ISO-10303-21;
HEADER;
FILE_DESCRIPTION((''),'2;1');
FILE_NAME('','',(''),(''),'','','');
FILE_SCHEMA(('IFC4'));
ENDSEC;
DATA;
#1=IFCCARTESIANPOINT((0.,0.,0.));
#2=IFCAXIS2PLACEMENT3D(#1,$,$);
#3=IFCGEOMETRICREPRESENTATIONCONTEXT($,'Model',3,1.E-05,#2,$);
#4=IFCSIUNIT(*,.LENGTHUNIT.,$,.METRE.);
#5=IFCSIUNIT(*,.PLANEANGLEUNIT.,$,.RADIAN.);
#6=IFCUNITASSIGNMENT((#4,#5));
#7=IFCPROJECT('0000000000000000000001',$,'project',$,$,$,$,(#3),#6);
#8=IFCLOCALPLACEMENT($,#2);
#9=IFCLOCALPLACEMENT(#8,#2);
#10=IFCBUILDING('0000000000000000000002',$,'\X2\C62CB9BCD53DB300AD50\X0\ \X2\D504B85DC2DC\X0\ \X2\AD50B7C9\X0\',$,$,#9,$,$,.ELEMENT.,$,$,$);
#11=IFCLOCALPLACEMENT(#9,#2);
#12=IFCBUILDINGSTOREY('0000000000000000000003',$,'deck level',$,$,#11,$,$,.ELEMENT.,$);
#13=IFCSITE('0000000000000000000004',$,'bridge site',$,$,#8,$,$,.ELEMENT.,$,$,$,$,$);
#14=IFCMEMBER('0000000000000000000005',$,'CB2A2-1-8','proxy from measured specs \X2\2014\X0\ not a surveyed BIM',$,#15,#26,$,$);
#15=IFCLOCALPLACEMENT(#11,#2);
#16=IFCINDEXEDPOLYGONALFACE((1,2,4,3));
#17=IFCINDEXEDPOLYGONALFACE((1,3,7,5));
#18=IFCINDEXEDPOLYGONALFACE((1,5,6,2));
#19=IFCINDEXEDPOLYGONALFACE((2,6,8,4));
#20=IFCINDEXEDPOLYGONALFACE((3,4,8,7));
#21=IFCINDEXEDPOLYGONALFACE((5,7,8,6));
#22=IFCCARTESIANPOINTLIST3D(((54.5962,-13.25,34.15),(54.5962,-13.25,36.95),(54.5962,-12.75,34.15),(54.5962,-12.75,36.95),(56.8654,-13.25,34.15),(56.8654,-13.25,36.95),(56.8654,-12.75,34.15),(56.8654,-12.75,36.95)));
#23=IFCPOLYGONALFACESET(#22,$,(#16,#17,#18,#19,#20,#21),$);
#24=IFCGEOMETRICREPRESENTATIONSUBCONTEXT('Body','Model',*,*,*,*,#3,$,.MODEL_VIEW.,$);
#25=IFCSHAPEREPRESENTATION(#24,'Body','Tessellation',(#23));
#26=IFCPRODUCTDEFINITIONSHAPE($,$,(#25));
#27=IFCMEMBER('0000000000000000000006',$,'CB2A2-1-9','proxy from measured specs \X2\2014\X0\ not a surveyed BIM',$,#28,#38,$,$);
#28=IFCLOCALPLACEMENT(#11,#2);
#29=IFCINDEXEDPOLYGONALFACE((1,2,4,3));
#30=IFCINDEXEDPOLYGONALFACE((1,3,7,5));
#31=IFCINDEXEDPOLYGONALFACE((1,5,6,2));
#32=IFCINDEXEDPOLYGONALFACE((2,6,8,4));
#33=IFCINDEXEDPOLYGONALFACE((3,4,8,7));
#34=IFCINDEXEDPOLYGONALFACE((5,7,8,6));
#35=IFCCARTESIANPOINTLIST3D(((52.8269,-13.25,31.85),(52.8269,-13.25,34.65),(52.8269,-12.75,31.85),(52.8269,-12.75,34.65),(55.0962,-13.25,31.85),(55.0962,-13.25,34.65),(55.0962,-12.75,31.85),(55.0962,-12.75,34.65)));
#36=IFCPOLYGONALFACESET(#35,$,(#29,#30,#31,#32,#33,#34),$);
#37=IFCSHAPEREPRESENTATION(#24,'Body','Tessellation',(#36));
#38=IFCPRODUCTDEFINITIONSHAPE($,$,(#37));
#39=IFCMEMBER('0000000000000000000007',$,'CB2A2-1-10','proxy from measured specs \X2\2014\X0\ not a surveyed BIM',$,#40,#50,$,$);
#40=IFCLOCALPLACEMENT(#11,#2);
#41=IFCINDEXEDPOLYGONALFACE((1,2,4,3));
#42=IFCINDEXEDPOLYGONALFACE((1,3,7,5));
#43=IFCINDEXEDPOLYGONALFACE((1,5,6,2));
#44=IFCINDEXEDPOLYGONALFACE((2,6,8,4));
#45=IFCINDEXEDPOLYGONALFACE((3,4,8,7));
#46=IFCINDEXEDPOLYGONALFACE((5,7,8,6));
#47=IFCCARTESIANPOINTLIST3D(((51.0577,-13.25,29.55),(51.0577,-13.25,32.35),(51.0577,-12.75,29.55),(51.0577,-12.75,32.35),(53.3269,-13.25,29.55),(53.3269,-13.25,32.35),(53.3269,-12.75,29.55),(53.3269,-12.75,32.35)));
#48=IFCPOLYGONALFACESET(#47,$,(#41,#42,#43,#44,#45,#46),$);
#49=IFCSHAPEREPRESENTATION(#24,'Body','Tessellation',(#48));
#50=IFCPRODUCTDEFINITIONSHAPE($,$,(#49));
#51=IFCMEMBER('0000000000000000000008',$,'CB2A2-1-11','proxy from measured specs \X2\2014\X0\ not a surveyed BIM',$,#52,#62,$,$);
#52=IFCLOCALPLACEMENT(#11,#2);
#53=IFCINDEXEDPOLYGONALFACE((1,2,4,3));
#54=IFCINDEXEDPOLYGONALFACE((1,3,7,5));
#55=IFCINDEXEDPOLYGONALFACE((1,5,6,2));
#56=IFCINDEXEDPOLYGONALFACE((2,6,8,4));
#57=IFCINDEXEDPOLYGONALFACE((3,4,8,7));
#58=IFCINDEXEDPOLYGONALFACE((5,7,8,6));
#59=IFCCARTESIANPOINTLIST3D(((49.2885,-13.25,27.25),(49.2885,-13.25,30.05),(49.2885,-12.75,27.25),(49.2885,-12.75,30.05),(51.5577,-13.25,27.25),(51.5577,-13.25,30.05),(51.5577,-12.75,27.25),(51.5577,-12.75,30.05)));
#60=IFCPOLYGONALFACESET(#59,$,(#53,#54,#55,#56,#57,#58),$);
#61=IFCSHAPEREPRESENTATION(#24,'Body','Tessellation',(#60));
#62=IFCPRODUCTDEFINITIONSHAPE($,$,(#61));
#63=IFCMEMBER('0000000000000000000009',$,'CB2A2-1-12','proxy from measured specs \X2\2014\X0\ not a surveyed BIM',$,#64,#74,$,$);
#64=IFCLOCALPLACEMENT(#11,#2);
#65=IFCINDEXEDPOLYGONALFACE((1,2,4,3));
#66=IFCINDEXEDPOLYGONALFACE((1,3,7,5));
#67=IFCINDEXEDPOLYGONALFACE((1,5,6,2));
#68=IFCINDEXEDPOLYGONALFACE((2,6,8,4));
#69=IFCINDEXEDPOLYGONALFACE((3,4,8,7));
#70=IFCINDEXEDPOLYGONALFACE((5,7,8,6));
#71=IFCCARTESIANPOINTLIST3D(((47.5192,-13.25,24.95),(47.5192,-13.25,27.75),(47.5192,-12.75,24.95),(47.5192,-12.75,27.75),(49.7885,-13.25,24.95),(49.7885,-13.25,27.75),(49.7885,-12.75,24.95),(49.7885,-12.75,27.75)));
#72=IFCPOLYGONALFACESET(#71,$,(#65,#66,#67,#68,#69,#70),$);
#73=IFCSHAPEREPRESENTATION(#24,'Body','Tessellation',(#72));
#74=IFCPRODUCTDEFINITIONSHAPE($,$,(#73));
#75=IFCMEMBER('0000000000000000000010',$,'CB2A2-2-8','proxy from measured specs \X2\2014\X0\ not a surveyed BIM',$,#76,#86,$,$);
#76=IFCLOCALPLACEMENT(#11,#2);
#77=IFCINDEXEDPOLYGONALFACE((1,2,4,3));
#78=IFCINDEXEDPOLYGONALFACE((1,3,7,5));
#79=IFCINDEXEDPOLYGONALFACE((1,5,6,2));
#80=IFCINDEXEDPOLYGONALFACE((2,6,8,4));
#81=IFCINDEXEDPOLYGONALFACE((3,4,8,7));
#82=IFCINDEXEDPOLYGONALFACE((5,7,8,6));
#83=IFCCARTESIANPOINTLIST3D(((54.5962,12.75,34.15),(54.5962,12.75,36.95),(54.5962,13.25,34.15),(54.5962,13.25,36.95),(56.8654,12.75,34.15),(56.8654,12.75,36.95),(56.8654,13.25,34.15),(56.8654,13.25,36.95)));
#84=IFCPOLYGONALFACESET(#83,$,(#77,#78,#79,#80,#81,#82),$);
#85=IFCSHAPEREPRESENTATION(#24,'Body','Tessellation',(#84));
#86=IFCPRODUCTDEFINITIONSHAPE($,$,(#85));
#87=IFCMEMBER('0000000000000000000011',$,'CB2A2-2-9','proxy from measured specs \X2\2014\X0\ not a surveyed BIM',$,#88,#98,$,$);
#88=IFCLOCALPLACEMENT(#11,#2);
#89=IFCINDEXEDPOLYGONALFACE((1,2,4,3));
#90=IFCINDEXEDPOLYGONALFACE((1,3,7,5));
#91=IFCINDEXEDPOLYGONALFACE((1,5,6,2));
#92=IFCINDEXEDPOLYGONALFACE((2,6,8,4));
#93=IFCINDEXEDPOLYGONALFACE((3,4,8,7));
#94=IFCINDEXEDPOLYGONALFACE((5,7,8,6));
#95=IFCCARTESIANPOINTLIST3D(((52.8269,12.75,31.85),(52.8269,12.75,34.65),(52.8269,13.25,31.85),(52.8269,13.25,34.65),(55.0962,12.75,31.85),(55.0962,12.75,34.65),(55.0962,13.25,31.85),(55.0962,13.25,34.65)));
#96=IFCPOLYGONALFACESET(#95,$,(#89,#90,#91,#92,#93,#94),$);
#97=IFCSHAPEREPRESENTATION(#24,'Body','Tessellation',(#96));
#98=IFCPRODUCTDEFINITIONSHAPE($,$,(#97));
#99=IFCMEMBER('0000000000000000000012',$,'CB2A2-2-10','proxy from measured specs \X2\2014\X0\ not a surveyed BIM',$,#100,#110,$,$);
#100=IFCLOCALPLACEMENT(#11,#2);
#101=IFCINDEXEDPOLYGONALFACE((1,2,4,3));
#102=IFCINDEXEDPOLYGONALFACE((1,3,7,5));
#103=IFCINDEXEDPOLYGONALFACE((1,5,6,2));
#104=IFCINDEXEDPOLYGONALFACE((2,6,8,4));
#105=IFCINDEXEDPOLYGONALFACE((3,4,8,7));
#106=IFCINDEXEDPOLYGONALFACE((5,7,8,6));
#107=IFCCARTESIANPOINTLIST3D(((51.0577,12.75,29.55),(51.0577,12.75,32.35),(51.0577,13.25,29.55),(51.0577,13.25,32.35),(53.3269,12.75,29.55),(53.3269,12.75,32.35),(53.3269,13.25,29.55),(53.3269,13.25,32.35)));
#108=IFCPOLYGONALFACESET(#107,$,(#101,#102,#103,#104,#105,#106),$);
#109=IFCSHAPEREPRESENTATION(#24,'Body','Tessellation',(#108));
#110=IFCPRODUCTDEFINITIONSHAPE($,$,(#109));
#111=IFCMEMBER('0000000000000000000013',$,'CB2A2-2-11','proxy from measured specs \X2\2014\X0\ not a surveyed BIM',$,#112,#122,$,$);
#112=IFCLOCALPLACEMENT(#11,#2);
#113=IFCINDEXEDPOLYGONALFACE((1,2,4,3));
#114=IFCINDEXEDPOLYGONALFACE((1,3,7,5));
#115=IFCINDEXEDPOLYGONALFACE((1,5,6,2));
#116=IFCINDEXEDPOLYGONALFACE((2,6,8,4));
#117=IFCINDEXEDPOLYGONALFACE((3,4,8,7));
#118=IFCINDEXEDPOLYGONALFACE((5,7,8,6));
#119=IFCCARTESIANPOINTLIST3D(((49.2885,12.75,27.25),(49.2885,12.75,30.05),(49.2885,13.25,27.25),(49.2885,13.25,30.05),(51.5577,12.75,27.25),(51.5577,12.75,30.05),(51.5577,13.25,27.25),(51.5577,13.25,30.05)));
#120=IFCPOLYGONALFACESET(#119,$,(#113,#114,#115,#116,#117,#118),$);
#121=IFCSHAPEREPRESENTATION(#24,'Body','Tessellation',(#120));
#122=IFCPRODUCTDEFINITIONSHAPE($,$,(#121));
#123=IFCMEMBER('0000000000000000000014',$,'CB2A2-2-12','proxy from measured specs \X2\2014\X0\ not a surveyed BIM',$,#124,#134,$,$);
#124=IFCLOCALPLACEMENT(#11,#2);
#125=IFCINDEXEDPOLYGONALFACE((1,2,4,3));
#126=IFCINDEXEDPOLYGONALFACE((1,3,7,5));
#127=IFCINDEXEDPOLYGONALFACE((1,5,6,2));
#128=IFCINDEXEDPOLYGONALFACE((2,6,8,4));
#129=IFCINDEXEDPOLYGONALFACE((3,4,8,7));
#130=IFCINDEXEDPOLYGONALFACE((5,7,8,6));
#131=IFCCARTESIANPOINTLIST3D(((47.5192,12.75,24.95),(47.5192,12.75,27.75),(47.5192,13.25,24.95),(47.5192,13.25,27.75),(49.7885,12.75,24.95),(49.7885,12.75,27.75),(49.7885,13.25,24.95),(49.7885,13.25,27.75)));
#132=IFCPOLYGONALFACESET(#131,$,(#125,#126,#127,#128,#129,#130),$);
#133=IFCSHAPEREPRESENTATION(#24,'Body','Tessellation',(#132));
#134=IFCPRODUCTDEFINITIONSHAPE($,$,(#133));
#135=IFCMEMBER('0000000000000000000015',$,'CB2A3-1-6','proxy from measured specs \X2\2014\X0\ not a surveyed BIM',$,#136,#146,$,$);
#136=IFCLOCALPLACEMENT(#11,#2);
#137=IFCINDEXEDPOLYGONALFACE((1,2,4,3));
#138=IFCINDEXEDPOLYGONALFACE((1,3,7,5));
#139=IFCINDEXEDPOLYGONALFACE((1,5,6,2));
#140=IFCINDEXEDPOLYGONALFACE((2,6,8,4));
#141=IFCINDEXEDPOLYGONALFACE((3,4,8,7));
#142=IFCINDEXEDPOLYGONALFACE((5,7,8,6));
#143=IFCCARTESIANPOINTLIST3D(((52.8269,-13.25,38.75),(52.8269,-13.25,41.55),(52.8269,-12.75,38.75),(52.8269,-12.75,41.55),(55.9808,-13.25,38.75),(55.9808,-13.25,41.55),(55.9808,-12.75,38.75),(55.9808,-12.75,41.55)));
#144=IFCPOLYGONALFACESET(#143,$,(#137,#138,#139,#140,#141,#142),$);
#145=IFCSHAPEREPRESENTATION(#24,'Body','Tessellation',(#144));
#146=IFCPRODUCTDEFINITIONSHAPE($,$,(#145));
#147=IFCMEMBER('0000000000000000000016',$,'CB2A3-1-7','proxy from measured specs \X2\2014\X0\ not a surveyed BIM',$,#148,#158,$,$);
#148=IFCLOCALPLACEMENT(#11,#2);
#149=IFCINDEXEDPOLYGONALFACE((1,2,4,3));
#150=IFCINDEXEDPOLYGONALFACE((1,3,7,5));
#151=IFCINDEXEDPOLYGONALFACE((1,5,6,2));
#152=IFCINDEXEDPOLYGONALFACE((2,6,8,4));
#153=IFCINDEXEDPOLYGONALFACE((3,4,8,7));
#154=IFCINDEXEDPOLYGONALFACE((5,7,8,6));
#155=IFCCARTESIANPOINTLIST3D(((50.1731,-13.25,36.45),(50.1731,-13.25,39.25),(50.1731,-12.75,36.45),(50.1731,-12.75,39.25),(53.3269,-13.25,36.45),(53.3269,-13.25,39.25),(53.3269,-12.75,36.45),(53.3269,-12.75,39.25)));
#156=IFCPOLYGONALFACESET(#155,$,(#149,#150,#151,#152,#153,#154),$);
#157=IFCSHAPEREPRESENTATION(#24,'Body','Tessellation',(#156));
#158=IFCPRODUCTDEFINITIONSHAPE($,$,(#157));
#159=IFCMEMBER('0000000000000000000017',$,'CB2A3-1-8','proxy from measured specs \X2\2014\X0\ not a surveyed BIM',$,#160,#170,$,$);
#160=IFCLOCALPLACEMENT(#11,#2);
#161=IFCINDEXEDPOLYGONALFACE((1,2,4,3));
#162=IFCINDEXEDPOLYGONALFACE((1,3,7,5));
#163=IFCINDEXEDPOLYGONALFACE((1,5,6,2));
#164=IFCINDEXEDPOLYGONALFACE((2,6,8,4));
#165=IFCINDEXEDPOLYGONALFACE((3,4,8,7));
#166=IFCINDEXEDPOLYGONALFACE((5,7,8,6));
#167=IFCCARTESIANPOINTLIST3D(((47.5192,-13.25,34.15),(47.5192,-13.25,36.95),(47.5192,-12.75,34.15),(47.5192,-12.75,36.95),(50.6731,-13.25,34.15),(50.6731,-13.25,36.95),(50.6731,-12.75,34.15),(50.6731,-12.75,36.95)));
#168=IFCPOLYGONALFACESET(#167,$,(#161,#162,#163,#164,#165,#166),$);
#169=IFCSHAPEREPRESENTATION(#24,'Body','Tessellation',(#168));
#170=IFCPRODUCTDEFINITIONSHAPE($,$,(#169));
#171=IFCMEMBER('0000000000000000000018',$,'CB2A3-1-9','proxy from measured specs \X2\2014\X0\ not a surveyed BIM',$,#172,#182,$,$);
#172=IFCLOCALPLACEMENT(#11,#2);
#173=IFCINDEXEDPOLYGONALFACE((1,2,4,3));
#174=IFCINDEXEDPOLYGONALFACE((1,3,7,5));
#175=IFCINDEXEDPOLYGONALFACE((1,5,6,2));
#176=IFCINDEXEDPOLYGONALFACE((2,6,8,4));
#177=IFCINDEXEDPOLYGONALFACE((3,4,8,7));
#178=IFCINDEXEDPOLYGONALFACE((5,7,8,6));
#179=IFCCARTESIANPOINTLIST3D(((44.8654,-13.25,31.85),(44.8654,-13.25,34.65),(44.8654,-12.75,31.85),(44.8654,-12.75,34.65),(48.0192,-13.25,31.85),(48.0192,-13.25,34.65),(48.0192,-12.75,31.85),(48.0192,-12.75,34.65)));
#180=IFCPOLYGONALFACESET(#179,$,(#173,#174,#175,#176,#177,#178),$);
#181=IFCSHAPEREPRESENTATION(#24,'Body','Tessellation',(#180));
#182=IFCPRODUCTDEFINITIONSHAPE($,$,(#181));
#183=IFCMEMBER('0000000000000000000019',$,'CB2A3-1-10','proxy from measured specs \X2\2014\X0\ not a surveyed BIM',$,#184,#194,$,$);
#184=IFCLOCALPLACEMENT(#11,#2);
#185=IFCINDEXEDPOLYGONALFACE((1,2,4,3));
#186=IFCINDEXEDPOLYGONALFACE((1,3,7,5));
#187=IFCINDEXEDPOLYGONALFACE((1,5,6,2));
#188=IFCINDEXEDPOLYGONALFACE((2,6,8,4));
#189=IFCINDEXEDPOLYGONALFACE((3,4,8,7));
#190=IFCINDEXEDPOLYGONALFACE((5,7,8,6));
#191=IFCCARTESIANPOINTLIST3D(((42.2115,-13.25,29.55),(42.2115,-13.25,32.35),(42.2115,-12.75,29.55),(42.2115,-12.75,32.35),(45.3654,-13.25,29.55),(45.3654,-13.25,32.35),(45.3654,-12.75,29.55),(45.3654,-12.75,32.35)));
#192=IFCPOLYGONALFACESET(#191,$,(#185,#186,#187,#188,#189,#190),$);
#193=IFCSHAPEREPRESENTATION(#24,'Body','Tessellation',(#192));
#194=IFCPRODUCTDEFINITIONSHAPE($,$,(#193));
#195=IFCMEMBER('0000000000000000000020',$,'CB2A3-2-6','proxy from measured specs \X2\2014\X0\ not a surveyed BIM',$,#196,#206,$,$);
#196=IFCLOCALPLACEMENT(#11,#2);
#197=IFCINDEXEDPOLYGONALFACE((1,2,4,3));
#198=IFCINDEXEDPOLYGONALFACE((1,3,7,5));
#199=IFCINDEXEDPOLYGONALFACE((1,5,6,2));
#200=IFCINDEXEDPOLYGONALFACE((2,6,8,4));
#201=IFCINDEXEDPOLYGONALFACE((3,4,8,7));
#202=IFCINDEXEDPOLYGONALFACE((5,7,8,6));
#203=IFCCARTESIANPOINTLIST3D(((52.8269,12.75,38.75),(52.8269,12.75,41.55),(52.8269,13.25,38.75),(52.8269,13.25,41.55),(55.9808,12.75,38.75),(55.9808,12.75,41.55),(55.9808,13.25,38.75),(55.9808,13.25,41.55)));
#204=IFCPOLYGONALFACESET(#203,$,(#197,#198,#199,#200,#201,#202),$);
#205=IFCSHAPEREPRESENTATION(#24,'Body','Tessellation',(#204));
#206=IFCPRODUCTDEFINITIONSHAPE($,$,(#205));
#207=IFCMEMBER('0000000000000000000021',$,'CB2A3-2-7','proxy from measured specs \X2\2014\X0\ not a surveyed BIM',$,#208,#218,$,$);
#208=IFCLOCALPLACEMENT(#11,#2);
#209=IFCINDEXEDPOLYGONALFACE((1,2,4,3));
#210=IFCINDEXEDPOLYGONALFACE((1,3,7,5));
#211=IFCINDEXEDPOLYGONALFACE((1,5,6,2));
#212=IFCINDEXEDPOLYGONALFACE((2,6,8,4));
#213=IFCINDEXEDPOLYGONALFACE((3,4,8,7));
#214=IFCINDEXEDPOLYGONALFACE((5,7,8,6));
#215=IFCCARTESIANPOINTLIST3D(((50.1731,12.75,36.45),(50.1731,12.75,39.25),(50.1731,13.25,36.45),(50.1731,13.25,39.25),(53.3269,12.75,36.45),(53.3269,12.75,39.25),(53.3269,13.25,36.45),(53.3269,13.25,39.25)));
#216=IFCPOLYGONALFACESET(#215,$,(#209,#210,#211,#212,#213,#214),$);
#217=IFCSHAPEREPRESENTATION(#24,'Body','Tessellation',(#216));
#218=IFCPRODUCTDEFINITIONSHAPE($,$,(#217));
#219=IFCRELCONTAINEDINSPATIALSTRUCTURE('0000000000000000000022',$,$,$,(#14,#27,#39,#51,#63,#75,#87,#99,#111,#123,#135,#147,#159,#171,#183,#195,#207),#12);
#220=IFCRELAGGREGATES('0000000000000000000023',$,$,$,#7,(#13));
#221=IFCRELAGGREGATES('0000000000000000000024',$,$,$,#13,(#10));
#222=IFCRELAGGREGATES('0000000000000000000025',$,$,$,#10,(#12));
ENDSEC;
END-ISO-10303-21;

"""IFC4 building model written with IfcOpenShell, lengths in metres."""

from ifc_helpers import new_model, si_unit, frame, origin, origin_2d, place, context, subcontext, project, spatial, rectangle, extrude, element, save


model = new_model("IFC4")

# Units and contexts
model_context = context("Model", 3, precision=1e-05, world=origin())
body_context = subcontext(model_context, "Body", "Model", "MODEL_VIEW")
ifc_project = project(units=[si_unit("LENGTHUNIT", "METRE"), si_unit("PLANEANGLEUNIT", "RADIAN")], contexts=[model_context])

# Site, building, storey
site_placement = place(None, origin())
site = spatial("IfcSite", under=ifc_project, at=site_placement, Name="bridge site", CompositionType="ELEMENT")
building_placement = place(site_placement, origin())
building = spatial("IfcBuilding", under=site, at=building_placement, Name="올림픽대교 프록시 교량", CompositionType="ELEMENT")
storey_placement = place(building_placement, origin())
storey = spatial("IfcBuildingStorey", under=building, at=storey_placement, Name="deck level", CompositionType="ELEMENT")

# Members
member_1_placement = place(storey_placement, frame((55.7308, -13.0, 34.15)))
element("IfcMember", 1, at=member_1_placement, inside=storey, Name="CB2A2-1-8", Description="proxy from measured specs — not a surveyed BIM", context=body_context, shape_type="SweptSolid", body=[
    extrude(rectangle(XDim=2.2692, YDim=0.5, at=origin_2d()), origin(), (0.0, 0.0, 1.0), 2.8),
])
member_2_placement = place(storey_placement, frame((53.9615, -13.0, 31.85)))
element("IfcMember", 2, at=member_2_placement, inside=storey, Name="CB2A2-1-9", Description="proxy from measured specs — not a surveyed BIM", context=body_context, shape_type="SweptSolid", body=[
    extrude(rectangle(XDim=2.2692, YDim=0.5, at=origin_2d()), origin(), (0.0, 0.0, 1.0), 2.8),
])
member_3_placement = place(storey_placement, frame((52.1923, -13.0, 29.55)))
element("IfcMember", 3, at=member_3_placement, inside=storey, Name="CB2A2-1-10", Description="proxy from measured specs — not a surveyed BIM", context=body_context, shape_type="SweptSolid", body=[
    extrude(rectangle(XDim=2.2692, YDim=0.5, at=origin_2d()), origin(), (0.0, 0.0, 1.0), 2.8),
])
member_4_placement = place(storey_placement, frame((50.4231, -13.0, 27.25)))
element("IfcMember", 4, at=member_4_placement, inside=storey, Name="CB2A2-1-11", Description="proxy from measured specs — not a surveyed BIM", context=body_context, shape_type="SweptSolid", body=[
    extrude(rectangle(XDim=2.2692, YDim=0.5, at=origin_2d()), origin(), (0.0, 0.0, 1.0), 2.8),
])
member_5_placement = place(storey_placement, frame((48.6538, -13.0, 24.95)))
element("IfcMember", 5, at=member_5_placement, inside=storey, Name="CB2A2-1-12", Description="proxy from measured specs — not a surveyed BIM", context=body_context, shape_type="SweptSolid", body=[
    extrude(rectangle(XDim=2.2692, YDim=0.5, at=origin_2d()), origin(), (0.0, 0.0, 1.0), 2.8),
])
member_6_placement = place(storey_placement, frame((55.7308, 13.0, 34.15)))
element("IfcMember", 6, at=member_6_placement, inside=storey, Name="CB2A2-2-8", Description="proxy from measured specs — not a surveyed BIM", context=body_context, shape_type="SweptSolid", body=[
    extrude(rectangle(XDim=2.2692, YDim=0.5, at=origin_2d()), origin(), (0.0, 0.0, 1.0), 2.8),
])
member_7_placement = place(storey_placement, frame((53.9615, 13.0, 31.85)))
element("IfcMember", 7, at=member_7_placement, inside=storey, Name="CB2A2-2-9", Description="proxy from measured specs — not a surveyed BIM", context=body_context, shape_type="SweptSolid", body=[
    extrude(rectangle(XDim=2.2692, YDim=0.5, at=origin_2d()), origin(), (0.0, 0.0, 1.0), 2.8),
])
member_8_placement = place(storey_placement, frame((52.1923, 13.0, 29.55)))
element("IfcMember", 8, at=member_8_placement, inside=storey, Name="CB2A2-2-10", Description="proxy from measured specs — not a surveyed BIM", context=body_context, shape_type="SweptSolid", body=[
    extrude(rectangle(XDim=2.2692, YDim=0.5, at=origin_2d()), origin(), (0.0, 0.0, 1.0), 2.8),
])
member_9_placement = place(storey_placement, frame((50.4231, 13.0, 27.25)))
element("IfcMember", 9, at=member_9_placement, inside=storey, Name="CB2A2-2-11", Description="proxy from measured specs — not a surveyed BIM", context=body_context, shape_type="SweptSolid", body=[
    extrude(rectangle(XDim=2.2692, YDim=0.5, at=origin_2d()), origin(), (0.0, 0.0, 1.0), 2.8),
])
member_10_placement = place(storey_placement, frame((48.6538, 13.0, 24.95)))
element("IfcMember", 10, at=member_10_placement, inside=storey, Name="CB2A2-2-12", Description="proxy from measured specs — not a surveyed BIM", context=body_context, shape_type="SweptSolid", body=[
    extrude(rectangle(XDim=2.2692, YDim=0.5, at=origin_2d()), origin(), (0.0, 0.0, 1.0), 2.8),
])
member_11_placement = place(storey_placement, frame((54.4038, -13.0, 38.75)))
element("IfcMember", 11, at=member_11_placement, inside=storey, Name="CB2A3-1-6", Description="proxy from measured specs — not a surveyed BIM", context=body_context, shape_type="SweptSolid", body=[
    extrude(rectangle(XDim=3.1538, YDim=0.5, at=origin_2d()), origin(), (0.0, 0.0, 1.0), 2.8),
])
member_12_placement = place(storey_placement, frame((51.75, -13.0, 36.45)))
element("IfcMember", 12, at=member_12_placement, inside=storey, Name="CB2A3-1-7", Description="proxy from measured specs — not a surveyed BIM", context=body_context, shape_type="SweptSolid", body=[
    extrude(rectangle(XDim=3.1538, YDim=0.5, at=origin_2d()), origin(), (0.0, 0.0, 1.0), 2.8),
])
member_13_placement = place(storey_placement, frame((49.0962, -13.0, 34.15)))
element("IfcMember", 13, at=member_13_placement, inside=storey, Name="CB2A3-1-8", Description="proxy from measured specs — not a surveyed BIM", context=body_context, shape_type="SweptSolid", body=[
    extrude(rectangle(XDim=3.1538, YDim=0.5, at=origin_2d()), origin(), (0.0, 0.0, 1.0), 2.8),
])
member_14_placement = place(storey_placement, frame((46.4423, -13.0, 31.85)))
element("IfcMember", 14, at=member_14_placement, inside=storey, Name="CB2A3-1-9", Description="proxy from measured specs — not a surveyed BIM", context=body_context, shape_type="SweptSolid", body=[
    extrude(rectangle(XDim=3.1538, YDim=0.5, at=origin_2d()), origin(), (0.0, 0.0, 1.0), 2.8),
])
member_15_placement = place(storey_placement, frame((43.7885, -13.0, 29.55)))
element("IfcMember", 15, at=member_15_placement, inside=storey, Name="CB2A3-1-10", Description="proxy from measured specs — not a surveyed BIM", context=body_context, shape_type="SweptSolid", body=[
    extrude(rectangle(XDim=3.1538, YDim=0.5, at=origin_2d()), origin(), (0.0, 0.0, 1.0), 2.8),
])
member_16_placement = place(storey_placement, frame((54.4038, 13.0, 38.75)))
element("IfcMember", 16, at=member_16_placement, inside=storey, Name="CB2A3-2-6", Description="proxy from measured specs — not a surveyed BIM", context=body_context, shape_type="SweptSolid", body=[
    extrude(rectangle(XDim=3.1538, YDim=0.5, at=origin_2d()), origin(), (0.0, 0.0, 1.0), 2.8),
])
member_17_placement = place(storey_placement, frame((51.75, 13.0, 36.45)))
element("IfcMember", 17, at=member_17_placement, inside=storey, Name="CB2A3-2-7", Description="proxy from measured specs — not a surveyed BIM", context=body_context, shape_type="SweptSolid", body=[
    extrude(rectangle(XDim=3.1538, YDim=0.5, at=origin_2d()), origin(), (0.0, 0.0, 1.0), 2.8),
])

save(model, "model.ifc")
